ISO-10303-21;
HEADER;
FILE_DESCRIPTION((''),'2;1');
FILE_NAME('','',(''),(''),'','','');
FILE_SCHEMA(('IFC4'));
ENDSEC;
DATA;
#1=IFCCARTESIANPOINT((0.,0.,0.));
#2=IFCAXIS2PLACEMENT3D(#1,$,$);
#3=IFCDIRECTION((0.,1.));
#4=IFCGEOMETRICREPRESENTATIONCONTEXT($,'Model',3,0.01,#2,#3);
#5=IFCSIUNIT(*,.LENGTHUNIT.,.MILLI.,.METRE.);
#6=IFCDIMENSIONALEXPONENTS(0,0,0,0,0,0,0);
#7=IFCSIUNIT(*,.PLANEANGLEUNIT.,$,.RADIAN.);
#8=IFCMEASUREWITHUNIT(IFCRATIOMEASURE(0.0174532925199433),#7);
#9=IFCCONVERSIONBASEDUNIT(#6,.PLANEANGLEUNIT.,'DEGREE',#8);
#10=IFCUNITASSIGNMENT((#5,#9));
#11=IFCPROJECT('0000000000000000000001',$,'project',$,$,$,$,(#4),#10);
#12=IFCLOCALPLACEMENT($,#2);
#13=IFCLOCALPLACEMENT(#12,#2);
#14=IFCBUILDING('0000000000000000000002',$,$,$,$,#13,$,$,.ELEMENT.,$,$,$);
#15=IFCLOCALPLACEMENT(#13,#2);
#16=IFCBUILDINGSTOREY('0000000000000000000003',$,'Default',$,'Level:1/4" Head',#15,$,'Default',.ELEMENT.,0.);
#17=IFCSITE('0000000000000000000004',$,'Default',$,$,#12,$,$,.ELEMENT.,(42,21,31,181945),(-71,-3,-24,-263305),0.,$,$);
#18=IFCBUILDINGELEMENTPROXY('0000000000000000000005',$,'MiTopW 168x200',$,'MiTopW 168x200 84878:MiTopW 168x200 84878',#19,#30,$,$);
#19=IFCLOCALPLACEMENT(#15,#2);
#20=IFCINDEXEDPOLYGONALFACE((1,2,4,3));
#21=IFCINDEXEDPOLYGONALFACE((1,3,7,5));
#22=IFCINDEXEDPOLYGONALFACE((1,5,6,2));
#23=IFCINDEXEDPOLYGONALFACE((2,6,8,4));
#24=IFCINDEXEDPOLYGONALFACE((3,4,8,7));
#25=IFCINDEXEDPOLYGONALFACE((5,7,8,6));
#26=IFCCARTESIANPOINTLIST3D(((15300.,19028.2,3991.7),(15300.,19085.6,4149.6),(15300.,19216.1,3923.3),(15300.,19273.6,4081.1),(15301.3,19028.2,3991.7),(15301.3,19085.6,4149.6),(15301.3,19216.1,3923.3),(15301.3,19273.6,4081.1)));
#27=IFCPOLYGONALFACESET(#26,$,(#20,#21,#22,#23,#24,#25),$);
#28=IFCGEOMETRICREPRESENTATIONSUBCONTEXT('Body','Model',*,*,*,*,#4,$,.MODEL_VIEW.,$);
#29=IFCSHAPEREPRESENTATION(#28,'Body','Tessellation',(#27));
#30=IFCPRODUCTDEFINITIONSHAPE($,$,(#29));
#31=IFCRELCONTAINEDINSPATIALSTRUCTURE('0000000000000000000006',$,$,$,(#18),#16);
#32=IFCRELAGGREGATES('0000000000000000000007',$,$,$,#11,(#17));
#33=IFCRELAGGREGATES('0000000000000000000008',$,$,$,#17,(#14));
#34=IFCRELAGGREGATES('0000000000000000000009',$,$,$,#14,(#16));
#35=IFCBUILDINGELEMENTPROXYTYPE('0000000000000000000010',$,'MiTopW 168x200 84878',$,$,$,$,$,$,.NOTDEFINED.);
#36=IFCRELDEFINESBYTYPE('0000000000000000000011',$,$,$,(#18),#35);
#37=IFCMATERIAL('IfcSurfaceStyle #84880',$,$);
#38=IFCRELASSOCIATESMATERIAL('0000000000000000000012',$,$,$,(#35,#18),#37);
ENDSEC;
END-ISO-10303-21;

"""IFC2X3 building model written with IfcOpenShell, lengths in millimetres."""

from ifc_helpers import new_model, entity, si_unit, converted_unit, direction, frame, origin, place, context, subcontext, project, spatial, polyline, outline, extrude, source, transform, mapped, material, type_object, type_shapes, element, save


model = new_model("IFC2X3")

# Units and contexts
model_context = context("Model", 3, precision=0.01, world=origin(), true_north=direction((0.0, 1.0)))
body_context = subcontext(model_context, "Body", "Model", "MODEL_VIEW")
ifc_project = project(units=[si_unit("LENGTHUNIT", "METRE", prefix="MILLI"), converted_unit("PLANEANGLEUNIT", "DEGREE", entity("IfcRatioMeasure", 0.0174532925199433), si_unit("PLANEANGLEUNIT", "RADIAN"), dimensions=[0, 0, 0, 0, 0, 0, 0])], contexts=[model_context])

# Site, building, storey
site_placement = place(None, origin())
site = spatial("IfcSite", under=ifc_project, at=site_placement, Name="Default", CompositionType="ELEMENT", RefLatitude=(42, 21, 31, 181945), RefLongitude=(-71, -3, -24, -263305), RefElevation=0.0)
building_placement = place(site_placement, origin())
building = spatial("IfcBuilding", under=site, at=building_placement, CompositionType="ELEMENT")
storey_placement = place(building_placement, origin())
storey = spatial("IfcBuildingStorey", under=building, at=storey_placement, Name="Default", ObjectType="Level:1/4\" Head", LongName="Default", CompositionType="ELEMENT", Elevation=0.0)

# Building element proxy
ifc_material_1 = material(Name="IfcSurfaceStyle #84880")
building_element_proxy_type_1 = type_object("IfcBuildingElementProxyType", Name="MiTopW 168x200 84878", PredefinedType="NOTDEFINED", material=ifc_material_1)
shared_shape_1 = source(origin(), body_context, "Body", "SweptSolid", [
    extrude(outline(polyline([(-100.0, -84.0), (100.0, -84.0), (100.0, 84.0), (-100.0, 84.0), (-100.0, -84.0)])), frame((100.0, 84.0, 0.0), z_axis=(0.0, 0.0, 1.0), x_axis=(-1.0, 0.0, 0.0)), (0.0, 0.0, 1.0), 1.3),
])
type_shapes(building_element_proxy_type_1, [shared_shape_1])
proxy_1_placement = place(building_placement, frame((15301.3, 19216.1, 3923.3), z_axis=(-1.0, 0.0, 0.0), x_axis=(0.0, -0.939693, 0.34202)))
element("IfcBuildingElementProxy", 1, at=proxy_1_placement, inside=storey, type_object=building_element_proxy_type_1, material=ifc_material_1, Name="MiTopW 168x200", ObjectType="MiTopW 168x200 84878:MiTopW 168x200 84878", context=body_context, shape_type="MappedRepresentation", body=[
    mapped(shared_shape_1, transform((0.0, 0.0, 0.0), scale=1.0)),
])

save(model, "model.ifc")
